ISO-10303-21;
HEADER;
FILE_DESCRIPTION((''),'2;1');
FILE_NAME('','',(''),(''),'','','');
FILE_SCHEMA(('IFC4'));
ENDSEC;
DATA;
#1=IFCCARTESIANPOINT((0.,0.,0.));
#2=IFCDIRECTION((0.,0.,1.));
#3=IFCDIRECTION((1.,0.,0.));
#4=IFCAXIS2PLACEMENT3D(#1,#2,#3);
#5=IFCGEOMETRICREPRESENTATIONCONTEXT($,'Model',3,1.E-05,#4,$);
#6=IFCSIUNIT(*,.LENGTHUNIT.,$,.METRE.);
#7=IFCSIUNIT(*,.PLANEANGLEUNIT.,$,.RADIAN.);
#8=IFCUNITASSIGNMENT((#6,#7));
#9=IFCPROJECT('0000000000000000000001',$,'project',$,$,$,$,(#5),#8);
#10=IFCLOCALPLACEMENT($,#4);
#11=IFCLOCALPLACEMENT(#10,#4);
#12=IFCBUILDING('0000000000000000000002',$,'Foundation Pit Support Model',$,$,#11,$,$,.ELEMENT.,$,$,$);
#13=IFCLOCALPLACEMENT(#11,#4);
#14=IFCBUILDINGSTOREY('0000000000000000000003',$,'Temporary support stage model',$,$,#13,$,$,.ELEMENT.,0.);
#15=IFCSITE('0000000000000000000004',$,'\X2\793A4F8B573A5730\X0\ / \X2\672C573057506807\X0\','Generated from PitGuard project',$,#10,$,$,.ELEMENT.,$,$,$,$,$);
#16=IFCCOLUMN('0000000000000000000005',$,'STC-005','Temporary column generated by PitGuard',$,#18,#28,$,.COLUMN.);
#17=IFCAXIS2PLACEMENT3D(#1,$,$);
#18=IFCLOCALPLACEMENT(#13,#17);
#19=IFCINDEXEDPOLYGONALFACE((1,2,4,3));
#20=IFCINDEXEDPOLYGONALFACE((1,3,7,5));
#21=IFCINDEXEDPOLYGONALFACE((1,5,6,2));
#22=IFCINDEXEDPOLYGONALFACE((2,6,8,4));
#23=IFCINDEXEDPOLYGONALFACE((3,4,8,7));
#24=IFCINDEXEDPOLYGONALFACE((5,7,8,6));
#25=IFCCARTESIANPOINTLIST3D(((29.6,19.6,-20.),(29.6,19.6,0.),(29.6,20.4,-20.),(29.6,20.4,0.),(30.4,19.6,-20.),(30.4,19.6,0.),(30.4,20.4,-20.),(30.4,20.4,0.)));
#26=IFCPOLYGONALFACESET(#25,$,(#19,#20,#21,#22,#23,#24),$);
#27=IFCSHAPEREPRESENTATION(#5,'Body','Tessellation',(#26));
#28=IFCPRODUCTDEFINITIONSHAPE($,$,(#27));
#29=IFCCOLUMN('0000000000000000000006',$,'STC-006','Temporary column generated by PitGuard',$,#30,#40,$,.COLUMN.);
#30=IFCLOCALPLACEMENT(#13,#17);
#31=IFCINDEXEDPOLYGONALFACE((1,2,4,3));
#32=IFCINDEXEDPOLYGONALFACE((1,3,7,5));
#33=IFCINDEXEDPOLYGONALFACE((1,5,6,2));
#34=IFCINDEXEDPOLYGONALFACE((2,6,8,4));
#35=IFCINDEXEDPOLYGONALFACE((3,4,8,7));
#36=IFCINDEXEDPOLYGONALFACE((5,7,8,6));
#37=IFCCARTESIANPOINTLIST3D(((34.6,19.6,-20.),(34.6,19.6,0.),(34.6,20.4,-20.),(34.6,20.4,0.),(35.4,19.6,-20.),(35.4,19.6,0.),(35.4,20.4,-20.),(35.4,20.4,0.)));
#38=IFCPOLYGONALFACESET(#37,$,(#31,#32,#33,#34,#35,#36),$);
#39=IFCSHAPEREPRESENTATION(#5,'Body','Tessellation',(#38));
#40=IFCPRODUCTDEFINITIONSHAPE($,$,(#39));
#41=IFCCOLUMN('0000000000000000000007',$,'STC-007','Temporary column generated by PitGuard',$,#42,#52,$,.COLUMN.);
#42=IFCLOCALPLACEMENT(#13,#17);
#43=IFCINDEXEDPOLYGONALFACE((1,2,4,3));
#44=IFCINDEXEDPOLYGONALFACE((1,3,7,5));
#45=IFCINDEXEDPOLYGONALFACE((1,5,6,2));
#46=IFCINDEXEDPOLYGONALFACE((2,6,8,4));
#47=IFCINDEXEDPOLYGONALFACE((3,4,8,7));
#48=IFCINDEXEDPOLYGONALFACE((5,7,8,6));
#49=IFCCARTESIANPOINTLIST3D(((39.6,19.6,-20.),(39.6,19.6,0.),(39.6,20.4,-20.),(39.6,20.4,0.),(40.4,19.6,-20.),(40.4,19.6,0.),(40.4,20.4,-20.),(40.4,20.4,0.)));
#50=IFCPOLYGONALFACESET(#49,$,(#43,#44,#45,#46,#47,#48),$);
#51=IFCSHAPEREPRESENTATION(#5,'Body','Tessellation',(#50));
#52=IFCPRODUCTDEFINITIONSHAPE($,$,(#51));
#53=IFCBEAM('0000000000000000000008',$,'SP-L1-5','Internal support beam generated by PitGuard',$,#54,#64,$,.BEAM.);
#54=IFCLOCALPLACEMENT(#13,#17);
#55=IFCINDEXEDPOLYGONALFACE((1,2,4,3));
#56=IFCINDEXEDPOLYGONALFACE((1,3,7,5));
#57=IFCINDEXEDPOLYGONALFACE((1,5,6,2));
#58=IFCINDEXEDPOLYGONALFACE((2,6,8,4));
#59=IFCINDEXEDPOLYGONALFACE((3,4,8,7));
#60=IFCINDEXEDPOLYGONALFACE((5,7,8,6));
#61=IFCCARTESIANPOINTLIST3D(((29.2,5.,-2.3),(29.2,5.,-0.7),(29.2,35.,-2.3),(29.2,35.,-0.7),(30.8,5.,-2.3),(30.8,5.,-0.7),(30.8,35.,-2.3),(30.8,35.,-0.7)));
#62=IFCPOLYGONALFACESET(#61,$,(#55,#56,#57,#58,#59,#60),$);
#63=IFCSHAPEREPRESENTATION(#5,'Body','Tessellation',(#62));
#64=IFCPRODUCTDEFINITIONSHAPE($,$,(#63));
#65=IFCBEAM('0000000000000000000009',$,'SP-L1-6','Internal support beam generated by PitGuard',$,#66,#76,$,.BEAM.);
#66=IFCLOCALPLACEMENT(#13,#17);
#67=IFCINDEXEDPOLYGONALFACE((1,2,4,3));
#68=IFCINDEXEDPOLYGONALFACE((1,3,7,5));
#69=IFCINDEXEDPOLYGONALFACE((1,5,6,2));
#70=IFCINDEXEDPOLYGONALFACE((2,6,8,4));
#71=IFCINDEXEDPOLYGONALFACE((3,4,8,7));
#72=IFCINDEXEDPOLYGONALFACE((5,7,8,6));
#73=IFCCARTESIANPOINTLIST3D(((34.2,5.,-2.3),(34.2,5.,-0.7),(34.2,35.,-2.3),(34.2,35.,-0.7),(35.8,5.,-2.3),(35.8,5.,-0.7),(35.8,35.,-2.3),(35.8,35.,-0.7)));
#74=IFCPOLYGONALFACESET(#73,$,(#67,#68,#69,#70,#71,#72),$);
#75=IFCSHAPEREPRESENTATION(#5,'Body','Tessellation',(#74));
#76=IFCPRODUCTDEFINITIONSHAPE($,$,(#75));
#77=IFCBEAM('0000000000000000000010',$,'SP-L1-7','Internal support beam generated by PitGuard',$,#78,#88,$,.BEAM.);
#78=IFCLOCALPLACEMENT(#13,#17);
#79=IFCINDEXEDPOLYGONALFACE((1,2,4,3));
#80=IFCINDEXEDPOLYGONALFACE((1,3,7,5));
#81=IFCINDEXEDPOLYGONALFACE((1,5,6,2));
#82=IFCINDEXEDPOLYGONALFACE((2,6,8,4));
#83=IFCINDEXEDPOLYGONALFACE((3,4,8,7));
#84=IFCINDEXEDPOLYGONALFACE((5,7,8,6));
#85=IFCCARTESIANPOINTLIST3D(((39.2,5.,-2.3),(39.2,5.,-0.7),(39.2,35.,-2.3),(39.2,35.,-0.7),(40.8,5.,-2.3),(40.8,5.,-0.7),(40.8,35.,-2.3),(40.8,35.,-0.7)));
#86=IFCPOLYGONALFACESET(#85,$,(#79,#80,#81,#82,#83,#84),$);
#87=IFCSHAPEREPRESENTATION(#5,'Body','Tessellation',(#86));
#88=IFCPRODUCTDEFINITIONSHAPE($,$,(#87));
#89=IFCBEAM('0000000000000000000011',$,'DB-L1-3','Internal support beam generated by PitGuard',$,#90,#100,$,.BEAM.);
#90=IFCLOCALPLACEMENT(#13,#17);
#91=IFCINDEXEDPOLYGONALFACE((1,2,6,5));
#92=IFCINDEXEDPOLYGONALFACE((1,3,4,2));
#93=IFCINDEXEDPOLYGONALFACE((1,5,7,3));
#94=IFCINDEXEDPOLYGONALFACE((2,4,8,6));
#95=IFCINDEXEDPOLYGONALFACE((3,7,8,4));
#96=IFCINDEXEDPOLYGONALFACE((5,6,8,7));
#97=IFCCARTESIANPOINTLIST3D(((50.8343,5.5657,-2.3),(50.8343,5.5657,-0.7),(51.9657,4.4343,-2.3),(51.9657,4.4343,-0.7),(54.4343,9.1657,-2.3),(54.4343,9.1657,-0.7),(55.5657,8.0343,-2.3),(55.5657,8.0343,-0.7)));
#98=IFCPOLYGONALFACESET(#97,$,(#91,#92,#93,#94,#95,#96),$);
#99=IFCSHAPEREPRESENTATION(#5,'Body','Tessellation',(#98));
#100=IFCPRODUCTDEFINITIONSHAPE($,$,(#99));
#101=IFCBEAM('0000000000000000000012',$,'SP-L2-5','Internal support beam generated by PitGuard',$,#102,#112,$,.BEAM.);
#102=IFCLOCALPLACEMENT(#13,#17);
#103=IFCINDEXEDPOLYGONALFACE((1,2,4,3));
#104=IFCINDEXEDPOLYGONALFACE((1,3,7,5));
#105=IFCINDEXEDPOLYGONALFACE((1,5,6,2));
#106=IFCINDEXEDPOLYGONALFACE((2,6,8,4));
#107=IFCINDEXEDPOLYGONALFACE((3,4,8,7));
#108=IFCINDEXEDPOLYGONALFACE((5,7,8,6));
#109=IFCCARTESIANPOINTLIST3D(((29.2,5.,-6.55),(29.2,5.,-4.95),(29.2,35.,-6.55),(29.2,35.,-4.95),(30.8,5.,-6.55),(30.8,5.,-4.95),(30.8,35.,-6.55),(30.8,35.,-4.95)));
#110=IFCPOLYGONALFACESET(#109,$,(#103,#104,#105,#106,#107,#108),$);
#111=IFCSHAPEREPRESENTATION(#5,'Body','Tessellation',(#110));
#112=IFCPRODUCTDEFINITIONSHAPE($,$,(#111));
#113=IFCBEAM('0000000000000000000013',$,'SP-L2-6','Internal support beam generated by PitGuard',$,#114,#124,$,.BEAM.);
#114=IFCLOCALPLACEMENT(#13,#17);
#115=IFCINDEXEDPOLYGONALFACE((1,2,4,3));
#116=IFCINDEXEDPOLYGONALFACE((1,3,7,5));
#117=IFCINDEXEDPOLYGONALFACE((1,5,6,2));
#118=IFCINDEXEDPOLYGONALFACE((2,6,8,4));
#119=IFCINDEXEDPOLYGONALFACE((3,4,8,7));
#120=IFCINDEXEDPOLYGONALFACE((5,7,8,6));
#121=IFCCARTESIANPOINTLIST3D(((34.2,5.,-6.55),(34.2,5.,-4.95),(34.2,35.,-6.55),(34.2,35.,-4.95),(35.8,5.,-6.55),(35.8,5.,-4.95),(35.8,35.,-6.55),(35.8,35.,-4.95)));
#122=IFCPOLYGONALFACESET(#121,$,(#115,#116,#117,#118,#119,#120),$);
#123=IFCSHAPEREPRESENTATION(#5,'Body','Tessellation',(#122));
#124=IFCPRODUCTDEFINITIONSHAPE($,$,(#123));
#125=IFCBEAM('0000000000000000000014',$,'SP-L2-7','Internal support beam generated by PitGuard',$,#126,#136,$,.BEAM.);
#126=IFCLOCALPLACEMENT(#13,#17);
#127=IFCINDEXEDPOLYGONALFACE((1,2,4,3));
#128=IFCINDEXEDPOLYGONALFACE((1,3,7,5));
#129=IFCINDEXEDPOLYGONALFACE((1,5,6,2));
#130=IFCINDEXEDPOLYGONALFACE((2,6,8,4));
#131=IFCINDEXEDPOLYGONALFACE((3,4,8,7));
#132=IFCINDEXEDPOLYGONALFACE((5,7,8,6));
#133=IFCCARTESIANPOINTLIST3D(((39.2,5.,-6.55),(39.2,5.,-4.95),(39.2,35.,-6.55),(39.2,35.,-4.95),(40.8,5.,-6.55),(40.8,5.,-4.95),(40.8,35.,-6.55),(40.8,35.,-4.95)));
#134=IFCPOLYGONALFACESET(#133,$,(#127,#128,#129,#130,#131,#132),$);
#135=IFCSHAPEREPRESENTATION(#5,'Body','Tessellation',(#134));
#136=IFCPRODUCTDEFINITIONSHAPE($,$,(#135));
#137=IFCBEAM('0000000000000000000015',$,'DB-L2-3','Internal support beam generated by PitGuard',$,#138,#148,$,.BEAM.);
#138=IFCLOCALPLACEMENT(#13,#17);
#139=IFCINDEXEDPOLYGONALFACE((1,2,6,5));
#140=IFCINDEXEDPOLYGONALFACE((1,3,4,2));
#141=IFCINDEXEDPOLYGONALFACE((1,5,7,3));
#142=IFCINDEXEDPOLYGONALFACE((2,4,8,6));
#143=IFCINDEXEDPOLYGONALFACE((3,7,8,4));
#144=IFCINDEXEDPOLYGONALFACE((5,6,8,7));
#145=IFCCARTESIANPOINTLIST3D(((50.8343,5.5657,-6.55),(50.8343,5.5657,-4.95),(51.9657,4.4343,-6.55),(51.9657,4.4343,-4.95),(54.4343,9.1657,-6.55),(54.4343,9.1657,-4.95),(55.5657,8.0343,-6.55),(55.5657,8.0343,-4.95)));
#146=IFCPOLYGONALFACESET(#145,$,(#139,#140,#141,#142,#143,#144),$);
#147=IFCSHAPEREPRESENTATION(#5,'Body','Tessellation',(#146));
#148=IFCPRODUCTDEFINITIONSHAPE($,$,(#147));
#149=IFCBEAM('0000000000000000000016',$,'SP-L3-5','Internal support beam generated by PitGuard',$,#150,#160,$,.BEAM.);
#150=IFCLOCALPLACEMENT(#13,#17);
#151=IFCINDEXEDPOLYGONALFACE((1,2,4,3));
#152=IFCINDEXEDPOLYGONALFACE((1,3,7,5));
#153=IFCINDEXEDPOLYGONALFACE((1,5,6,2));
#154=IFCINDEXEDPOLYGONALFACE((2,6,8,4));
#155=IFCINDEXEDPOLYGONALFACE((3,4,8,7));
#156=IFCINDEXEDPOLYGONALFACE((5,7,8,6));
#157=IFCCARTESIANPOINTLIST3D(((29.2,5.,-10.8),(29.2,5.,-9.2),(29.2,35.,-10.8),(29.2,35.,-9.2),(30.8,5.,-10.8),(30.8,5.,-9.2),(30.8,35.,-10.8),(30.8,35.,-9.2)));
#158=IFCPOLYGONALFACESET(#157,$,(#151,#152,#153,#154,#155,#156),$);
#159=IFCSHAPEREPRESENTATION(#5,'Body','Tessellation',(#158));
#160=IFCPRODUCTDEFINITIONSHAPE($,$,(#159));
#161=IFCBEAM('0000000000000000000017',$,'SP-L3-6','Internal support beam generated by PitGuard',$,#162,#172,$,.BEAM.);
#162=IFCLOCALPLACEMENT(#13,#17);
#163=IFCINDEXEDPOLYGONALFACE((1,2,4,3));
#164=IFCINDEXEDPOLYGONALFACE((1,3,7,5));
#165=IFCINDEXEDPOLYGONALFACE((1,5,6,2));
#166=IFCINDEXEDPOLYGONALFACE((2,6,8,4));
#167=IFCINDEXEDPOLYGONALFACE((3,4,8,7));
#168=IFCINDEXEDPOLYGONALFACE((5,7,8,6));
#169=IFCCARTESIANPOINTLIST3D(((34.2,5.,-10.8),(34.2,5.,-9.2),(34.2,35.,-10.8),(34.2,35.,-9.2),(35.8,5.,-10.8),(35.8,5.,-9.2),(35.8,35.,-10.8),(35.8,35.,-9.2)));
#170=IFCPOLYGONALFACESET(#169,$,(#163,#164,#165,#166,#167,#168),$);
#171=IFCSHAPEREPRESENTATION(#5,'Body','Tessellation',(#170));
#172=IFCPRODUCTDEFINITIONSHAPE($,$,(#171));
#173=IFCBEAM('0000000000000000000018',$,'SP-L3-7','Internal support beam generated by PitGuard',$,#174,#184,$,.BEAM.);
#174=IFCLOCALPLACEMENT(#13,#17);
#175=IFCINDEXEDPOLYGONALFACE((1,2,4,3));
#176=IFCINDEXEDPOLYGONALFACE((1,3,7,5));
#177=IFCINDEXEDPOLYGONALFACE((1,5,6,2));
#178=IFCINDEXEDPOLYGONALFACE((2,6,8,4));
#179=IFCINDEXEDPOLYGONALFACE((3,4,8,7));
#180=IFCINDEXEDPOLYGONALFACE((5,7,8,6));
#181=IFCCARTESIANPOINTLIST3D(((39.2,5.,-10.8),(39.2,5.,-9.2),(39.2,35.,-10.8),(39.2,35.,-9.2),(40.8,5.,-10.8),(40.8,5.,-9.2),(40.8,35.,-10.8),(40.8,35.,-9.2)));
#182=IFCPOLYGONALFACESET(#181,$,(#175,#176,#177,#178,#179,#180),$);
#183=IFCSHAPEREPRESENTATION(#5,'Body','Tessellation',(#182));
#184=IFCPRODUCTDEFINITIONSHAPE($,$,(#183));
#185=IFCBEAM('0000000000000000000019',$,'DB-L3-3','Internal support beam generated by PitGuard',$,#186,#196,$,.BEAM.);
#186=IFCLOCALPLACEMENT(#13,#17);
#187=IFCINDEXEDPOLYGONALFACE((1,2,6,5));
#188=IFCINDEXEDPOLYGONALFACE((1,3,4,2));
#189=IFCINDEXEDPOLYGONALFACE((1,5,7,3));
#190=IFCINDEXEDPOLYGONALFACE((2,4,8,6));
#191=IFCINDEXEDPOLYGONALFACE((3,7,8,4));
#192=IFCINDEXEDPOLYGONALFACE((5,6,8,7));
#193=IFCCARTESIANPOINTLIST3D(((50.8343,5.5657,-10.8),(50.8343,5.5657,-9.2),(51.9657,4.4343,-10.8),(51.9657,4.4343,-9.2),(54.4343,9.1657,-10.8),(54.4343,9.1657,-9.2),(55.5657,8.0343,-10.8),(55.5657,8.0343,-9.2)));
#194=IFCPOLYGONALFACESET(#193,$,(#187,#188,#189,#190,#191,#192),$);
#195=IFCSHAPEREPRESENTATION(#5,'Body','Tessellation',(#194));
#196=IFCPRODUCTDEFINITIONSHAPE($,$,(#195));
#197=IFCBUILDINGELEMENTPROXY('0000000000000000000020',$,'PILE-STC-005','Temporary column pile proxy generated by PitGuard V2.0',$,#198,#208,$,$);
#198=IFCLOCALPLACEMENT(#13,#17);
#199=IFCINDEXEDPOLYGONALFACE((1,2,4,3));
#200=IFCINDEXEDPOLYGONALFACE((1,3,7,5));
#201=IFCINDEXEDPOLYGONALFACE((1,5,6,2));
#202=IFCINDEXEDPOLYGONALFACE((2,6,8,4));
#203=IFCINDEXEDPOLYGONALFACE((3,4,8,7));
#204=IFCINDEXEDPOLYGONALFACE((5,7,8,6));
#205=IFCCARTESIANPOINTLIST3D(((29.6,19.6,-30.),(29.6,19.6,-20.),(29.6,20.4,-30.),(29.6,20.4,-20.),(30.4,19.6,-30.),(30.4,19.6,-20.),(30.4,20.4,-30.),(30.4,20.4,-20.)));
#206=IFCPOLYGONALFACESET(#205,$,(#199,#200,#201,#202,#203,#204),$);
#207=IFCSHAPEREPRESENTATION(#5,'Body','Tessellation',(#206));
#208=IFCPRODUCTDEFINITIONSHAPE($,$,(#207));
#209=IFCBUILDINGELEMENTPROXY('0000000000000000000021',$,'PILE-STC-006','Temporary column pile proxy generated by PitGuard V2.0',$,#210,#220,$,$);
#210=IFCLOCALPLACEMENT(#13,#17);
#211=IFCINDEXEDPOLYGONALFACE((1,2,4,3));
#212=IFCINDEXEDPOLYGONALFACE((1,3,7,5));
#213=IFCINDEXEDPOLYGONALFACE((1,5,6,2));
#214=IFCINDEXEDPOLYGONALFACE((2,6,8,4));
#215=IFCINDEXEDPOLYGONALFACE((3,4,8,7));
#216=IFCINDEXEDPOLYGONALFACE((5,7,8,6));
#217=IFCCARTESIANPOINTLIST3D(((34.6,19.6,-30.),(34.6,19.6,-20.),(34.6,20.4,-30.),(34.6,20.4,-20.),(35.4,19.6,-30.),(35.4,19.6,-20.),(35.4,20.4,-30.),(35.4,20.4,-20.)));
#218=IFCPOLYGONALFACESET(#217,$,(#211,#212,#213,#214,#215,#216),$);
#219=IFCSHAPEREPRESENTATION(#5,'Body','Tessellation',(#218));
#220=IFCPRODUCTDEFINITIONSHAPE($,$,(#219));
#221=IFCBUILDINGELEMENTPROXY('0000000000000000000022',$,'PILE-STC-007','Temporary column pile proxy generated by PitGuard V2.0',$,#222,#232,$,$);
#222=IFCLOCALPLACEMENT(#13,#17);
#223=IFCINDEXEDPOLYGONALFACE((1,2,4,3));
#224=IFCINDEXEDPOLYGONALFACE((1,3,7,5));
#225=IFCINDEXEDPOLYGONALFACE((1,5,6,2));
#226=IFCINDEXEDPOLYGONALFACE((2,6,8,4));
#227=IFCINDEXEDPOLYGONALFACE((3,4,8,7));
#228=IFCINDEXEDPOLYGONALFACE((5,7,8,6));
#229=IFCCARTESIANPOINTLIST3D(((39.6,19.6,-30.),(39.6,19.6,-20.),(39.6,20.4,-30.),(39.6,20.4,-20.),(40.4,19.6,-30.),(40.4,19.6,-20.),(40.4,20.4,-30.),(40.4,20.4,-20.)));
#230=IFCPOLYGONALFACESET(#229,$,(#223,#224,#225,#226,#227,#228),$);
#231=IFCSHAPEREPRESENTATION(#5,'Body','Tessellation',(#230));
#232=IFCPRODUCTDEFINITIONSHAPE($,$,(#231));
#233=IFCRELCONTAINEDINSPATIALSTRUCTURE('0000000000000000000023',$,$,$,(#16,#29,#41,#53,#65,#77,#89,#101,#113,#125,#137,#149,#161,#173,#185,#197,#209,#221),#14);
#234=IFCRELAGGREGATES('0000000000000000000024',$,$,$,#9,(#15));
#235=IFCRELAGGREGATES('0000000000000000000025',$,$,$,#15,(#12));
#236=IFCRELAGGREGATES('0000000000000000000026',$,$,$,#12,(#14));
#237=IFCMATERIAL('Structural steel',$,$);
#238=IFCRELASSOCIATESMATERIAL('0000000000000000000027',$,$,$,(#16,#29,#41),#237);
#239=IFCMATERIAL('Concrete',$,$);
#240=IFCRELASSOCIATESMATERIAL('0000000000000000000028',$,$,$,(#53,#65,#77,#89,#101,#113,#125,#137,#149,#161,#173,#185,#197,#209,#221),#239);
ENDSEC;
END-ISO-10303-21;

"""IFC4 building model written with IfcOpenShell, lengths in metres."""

from ifc_helpers import new_model, si_unit, frame, origin_with_axes, origin_2d, place, context, project, spatial, rectangle, extrude, material, element, save


model = new_model("IFC4")

# Units and contexts
model_context = context("Model", 3, precision=1e-05, world=origin_with_axes())
ifc_project = project(units=[si_unit("LENGTHUNIT", "METRE"), si_unit("PLANEANGLEUNIT", "RADIAN")], contexts=[model_context])

# Site, building, storey
site_placement = place(None, origin_with_axes())
site = spatial("IfcSite", under=ifc_project, at=site_placement, Name="示例场地 / 本地坐标", Description="Generated from PitGuard project", CompositionType="ELEMENT")
building_placement = place(site_placement, origin_with_axes())
building = spatial("IfcBuilding", under=site, at=building_placement, Name="Foundation Pit Support Model", CompositionType="ELEMENT")
storey_placement = place(building_placement, origin_with_axes())
storey = spatial("IfcBuildingStorey", under=building, at=storey_placement, Name="Temporary support stage model", CompositionType="ELEMENT", Elevation=0.0)

# Columns
ifc_material_1 = material(Name="Structural steel")
for number, where, z_axis, x_axis, name in (
    (1, (30.0, 20.0, -20.0), (0.0, 0.0, 1.0), (1.0, 0.0, 0.0), "STC-005"),
    (2, (35.0, 20.0, -20.0), (0.0, 0.0, 1.0), (1.0, 0.0, 0.0), "STC-006"),
    (3, (40.0, 20.0, -20.0), (0.0, 0.0, 1.0), (1.0, 0.0, 0.0), "STC-007"),
):
    element("IfcColumn", number, at=place(storey_placement, frame(where, z_axis=z_axis, x_axis=x_axis)), inside=storey, material=ifc_material_1, Name=name, Description="Temporary column generated by PitGuard", PredefinedType="COLUMN", context=model_context, shape_type="SweptSolid", body=[
        extrude(rectangle(XDim=0.8, YDim=0.8, at=origin_2d()), origin_with_axes(), (0.0, 0.0, 1.0), 20.0),
    ])

# Beams
ifc_material_2 = material(Name="Concrete")
for number, where, z_axis, x_axis, name in (
    (4, (30.0, 20.0, -2.3), (0.0, 0.0, 1.0), (0.0, 1.0, 0.0), "SP-L1-5"),
    (5, (35.0, 20.0, -2.3), (0.0, 0.0, 1.0), (0.0, 1.0, 0.0), "SP-L1-6"),
    (6, (40.0, 20.0, -2.3), (0.0, 0.0, 1.0), (0.0, 1.0, 0.0), "SP-L1-7"),
):
    element("IfcBeam", number, at=place(storey_placement, frame(where, z_axis=z_axis, x_axis=x_axis)), inside=storey, material=ifc_material_2, Name=name, Description="Internal support beam generated by PitGuard", PredefinedType="BEAM", context=model_context, shape_type="SweptSolid", body=[
        extrude(rectangle(XDim=30.0, YDim=1.6, at=origin_2d()), origin_with_axes(), (0.0, 0.0, 1.0), 1.6),
    ])
beam_1_placement = place(storey_placement, frame((53.2, 6.8, -2.3), z_axis=(0.0, 0.0, 1.0), x_axis=(0.707107, 0.707107, 0.0)))
element("IfcBeam", 7, at=beam_1_placement, inside=storey, material=ifc_material_2, Name="DB-L1-3", Description="Internal support beam generated by PitGuard", PredefinedType="BEAM", context=model_context, shape_type="SweptSolid", body=[
    extrude(rectangle(XDim=5.0912, YDim=1.6, at=origin_2d()), origin_with_axes(), (0.0, 0.0, 1.0), 1.6),
])
for number, where, z_axis, x_axis, name in (
    (8, (30.0, 20.0, -6.55), (0.0, 0.0, 1.0), (0.0, 1.0, 0.0), "SP-L2-5"),
    (9, (35.0, 20.0, -6.55), (0.0, 0.0, 1.0), (0.0, 1.0, 0.0), "SP-L2-6"),
    (10, (40.0, 20.0, -6.55), (0.0, 0.0, 1.0), (0.0, 1.0, 0.0), "SP-L2-7"),
):
    element("IfcBeam", number, at=place(storey_placement, frame(where, z_axis=z_axis, x_axis=x_axis)), inside=storey, material=ifc_material_2, Name=name, Description="Internal support beam generated by PitGuard", PredefinedType="BEAM", context=model_context, shape_type="SweptSolid", body=[
        extrude(rectangle(XDim=30.0, YDim=1.6, at=origin_2d()), origin_with_axes(), (0.0, 0.0, 1.0), 1.6),
    ])
beam_2_placement = place(storey_placement, frame((53.2, 6.8, -6.55), z_axis=(0.0, 0.0, 1.0), x_axis=(0.707107, 0.707107, 0.0)))
element("IfcBeam", 11, at=beam_2_placement, inside=storey, material=ifc_material_2, Name="DB-L2-3", Description="Internal support beam generated by PitGuard", PredefinedType="BEAM", context=model_context, shape_type="SweptSolid", body=[
    extrude(rectangle(XDim=5.0912, YDim=1.6, at=origin_2d()), origin_with_axes(), (0.0, 0.0, 1.0), 1.6),
])
for number, where, z_axis, x_axis, name in (
    (12, (30.0, 20.0, -10.8), (0.0, 0.0, 1.0), (0.0, 1.0, 0.0), "SP-L3-5"),
    (13, (35.0, 20.0, -10.8), (0.0, 0.0, 1.0), (0.0, 1.0, 0.0), "SP-L3-6"),
    (14, (40.0, 20.0, -10.8), (0.0, 0.0, 1.0), (0.0, 1.0, 0.0), "SP-L3-7"),
):
    element("IfcBeam", number, at=place(storey_placement, frame(where, z_axis=z_axis, x_axis=x_axis)), inside=storey, material=ifc_material_2, Name=name, Description="Internal support beam generated by PitGuard", PredefinedType="BEAM", context=model_context, shape_type="SweptSolid", body=[
        extrude(rectangle(XDim=30.0, YDim=1.6, at=origin_2d()), origin_with_axes(), (0.0, 0.0, 1.0), 1.6),
    ])
beam_3_placement = place(storey_placement, frame((53.2, 6.8, -10.8), z_axis=(0.0, 0.0, 1.0), x_axis=(0.707107, 0.707107, 0.0)))
element("IfcBeam", 15, at=beam_3_placement, inside=storey, material=ifc_material_2, Name="DB-L3-3", Description="Internal support beam generated by PitGuard", PredefinedType="BEAM", context=model_context, shape_type="SweptSolid", body=[
    extrude(rectangle(XDim=5.0912, YDim=1.6, at=origin_2d()), origin_with_axes(), (0.0, 0.0, 1.0), 1.6),
])

# Building element proxies
for number, where, z_axis, x_axis, name in (
    (16, (30.0, 20.0, -30.0), (0.0, 0.0, 1.0), (1.0, 0.0, 0.0), "PILE-STC-005"),
    (17, (35.0, 20.0, -30.0), (0.0, 0.0, 1.0), (1.0, 0.0, 0.0), "PILE-STC-006"),
    (18, (40.0, 20.0, -30.0), (0.0, 0.0, 1.0), (1.0, 0.0, 0.0), "PILE-STC-007"),
):
    element("IfcBuildingElementProxy", number, at=place(storey_placement, frame(where, z_axis=z_axis, x_axis=x_axis)), inside=storey, material=ifc_material_2, Name=name, Description="Temporary column pile proxy generated by PitGuard V2.0", context=model_context, shape_type="SweptSolid", body=[
        extrude(rectangle(XDim=0.8, YDim=0.8, at=origin_2d()), origin_with_axes(), (0.0, 0.0, 1.0), 10.0),
    ])

save(model, "model.ifc")
